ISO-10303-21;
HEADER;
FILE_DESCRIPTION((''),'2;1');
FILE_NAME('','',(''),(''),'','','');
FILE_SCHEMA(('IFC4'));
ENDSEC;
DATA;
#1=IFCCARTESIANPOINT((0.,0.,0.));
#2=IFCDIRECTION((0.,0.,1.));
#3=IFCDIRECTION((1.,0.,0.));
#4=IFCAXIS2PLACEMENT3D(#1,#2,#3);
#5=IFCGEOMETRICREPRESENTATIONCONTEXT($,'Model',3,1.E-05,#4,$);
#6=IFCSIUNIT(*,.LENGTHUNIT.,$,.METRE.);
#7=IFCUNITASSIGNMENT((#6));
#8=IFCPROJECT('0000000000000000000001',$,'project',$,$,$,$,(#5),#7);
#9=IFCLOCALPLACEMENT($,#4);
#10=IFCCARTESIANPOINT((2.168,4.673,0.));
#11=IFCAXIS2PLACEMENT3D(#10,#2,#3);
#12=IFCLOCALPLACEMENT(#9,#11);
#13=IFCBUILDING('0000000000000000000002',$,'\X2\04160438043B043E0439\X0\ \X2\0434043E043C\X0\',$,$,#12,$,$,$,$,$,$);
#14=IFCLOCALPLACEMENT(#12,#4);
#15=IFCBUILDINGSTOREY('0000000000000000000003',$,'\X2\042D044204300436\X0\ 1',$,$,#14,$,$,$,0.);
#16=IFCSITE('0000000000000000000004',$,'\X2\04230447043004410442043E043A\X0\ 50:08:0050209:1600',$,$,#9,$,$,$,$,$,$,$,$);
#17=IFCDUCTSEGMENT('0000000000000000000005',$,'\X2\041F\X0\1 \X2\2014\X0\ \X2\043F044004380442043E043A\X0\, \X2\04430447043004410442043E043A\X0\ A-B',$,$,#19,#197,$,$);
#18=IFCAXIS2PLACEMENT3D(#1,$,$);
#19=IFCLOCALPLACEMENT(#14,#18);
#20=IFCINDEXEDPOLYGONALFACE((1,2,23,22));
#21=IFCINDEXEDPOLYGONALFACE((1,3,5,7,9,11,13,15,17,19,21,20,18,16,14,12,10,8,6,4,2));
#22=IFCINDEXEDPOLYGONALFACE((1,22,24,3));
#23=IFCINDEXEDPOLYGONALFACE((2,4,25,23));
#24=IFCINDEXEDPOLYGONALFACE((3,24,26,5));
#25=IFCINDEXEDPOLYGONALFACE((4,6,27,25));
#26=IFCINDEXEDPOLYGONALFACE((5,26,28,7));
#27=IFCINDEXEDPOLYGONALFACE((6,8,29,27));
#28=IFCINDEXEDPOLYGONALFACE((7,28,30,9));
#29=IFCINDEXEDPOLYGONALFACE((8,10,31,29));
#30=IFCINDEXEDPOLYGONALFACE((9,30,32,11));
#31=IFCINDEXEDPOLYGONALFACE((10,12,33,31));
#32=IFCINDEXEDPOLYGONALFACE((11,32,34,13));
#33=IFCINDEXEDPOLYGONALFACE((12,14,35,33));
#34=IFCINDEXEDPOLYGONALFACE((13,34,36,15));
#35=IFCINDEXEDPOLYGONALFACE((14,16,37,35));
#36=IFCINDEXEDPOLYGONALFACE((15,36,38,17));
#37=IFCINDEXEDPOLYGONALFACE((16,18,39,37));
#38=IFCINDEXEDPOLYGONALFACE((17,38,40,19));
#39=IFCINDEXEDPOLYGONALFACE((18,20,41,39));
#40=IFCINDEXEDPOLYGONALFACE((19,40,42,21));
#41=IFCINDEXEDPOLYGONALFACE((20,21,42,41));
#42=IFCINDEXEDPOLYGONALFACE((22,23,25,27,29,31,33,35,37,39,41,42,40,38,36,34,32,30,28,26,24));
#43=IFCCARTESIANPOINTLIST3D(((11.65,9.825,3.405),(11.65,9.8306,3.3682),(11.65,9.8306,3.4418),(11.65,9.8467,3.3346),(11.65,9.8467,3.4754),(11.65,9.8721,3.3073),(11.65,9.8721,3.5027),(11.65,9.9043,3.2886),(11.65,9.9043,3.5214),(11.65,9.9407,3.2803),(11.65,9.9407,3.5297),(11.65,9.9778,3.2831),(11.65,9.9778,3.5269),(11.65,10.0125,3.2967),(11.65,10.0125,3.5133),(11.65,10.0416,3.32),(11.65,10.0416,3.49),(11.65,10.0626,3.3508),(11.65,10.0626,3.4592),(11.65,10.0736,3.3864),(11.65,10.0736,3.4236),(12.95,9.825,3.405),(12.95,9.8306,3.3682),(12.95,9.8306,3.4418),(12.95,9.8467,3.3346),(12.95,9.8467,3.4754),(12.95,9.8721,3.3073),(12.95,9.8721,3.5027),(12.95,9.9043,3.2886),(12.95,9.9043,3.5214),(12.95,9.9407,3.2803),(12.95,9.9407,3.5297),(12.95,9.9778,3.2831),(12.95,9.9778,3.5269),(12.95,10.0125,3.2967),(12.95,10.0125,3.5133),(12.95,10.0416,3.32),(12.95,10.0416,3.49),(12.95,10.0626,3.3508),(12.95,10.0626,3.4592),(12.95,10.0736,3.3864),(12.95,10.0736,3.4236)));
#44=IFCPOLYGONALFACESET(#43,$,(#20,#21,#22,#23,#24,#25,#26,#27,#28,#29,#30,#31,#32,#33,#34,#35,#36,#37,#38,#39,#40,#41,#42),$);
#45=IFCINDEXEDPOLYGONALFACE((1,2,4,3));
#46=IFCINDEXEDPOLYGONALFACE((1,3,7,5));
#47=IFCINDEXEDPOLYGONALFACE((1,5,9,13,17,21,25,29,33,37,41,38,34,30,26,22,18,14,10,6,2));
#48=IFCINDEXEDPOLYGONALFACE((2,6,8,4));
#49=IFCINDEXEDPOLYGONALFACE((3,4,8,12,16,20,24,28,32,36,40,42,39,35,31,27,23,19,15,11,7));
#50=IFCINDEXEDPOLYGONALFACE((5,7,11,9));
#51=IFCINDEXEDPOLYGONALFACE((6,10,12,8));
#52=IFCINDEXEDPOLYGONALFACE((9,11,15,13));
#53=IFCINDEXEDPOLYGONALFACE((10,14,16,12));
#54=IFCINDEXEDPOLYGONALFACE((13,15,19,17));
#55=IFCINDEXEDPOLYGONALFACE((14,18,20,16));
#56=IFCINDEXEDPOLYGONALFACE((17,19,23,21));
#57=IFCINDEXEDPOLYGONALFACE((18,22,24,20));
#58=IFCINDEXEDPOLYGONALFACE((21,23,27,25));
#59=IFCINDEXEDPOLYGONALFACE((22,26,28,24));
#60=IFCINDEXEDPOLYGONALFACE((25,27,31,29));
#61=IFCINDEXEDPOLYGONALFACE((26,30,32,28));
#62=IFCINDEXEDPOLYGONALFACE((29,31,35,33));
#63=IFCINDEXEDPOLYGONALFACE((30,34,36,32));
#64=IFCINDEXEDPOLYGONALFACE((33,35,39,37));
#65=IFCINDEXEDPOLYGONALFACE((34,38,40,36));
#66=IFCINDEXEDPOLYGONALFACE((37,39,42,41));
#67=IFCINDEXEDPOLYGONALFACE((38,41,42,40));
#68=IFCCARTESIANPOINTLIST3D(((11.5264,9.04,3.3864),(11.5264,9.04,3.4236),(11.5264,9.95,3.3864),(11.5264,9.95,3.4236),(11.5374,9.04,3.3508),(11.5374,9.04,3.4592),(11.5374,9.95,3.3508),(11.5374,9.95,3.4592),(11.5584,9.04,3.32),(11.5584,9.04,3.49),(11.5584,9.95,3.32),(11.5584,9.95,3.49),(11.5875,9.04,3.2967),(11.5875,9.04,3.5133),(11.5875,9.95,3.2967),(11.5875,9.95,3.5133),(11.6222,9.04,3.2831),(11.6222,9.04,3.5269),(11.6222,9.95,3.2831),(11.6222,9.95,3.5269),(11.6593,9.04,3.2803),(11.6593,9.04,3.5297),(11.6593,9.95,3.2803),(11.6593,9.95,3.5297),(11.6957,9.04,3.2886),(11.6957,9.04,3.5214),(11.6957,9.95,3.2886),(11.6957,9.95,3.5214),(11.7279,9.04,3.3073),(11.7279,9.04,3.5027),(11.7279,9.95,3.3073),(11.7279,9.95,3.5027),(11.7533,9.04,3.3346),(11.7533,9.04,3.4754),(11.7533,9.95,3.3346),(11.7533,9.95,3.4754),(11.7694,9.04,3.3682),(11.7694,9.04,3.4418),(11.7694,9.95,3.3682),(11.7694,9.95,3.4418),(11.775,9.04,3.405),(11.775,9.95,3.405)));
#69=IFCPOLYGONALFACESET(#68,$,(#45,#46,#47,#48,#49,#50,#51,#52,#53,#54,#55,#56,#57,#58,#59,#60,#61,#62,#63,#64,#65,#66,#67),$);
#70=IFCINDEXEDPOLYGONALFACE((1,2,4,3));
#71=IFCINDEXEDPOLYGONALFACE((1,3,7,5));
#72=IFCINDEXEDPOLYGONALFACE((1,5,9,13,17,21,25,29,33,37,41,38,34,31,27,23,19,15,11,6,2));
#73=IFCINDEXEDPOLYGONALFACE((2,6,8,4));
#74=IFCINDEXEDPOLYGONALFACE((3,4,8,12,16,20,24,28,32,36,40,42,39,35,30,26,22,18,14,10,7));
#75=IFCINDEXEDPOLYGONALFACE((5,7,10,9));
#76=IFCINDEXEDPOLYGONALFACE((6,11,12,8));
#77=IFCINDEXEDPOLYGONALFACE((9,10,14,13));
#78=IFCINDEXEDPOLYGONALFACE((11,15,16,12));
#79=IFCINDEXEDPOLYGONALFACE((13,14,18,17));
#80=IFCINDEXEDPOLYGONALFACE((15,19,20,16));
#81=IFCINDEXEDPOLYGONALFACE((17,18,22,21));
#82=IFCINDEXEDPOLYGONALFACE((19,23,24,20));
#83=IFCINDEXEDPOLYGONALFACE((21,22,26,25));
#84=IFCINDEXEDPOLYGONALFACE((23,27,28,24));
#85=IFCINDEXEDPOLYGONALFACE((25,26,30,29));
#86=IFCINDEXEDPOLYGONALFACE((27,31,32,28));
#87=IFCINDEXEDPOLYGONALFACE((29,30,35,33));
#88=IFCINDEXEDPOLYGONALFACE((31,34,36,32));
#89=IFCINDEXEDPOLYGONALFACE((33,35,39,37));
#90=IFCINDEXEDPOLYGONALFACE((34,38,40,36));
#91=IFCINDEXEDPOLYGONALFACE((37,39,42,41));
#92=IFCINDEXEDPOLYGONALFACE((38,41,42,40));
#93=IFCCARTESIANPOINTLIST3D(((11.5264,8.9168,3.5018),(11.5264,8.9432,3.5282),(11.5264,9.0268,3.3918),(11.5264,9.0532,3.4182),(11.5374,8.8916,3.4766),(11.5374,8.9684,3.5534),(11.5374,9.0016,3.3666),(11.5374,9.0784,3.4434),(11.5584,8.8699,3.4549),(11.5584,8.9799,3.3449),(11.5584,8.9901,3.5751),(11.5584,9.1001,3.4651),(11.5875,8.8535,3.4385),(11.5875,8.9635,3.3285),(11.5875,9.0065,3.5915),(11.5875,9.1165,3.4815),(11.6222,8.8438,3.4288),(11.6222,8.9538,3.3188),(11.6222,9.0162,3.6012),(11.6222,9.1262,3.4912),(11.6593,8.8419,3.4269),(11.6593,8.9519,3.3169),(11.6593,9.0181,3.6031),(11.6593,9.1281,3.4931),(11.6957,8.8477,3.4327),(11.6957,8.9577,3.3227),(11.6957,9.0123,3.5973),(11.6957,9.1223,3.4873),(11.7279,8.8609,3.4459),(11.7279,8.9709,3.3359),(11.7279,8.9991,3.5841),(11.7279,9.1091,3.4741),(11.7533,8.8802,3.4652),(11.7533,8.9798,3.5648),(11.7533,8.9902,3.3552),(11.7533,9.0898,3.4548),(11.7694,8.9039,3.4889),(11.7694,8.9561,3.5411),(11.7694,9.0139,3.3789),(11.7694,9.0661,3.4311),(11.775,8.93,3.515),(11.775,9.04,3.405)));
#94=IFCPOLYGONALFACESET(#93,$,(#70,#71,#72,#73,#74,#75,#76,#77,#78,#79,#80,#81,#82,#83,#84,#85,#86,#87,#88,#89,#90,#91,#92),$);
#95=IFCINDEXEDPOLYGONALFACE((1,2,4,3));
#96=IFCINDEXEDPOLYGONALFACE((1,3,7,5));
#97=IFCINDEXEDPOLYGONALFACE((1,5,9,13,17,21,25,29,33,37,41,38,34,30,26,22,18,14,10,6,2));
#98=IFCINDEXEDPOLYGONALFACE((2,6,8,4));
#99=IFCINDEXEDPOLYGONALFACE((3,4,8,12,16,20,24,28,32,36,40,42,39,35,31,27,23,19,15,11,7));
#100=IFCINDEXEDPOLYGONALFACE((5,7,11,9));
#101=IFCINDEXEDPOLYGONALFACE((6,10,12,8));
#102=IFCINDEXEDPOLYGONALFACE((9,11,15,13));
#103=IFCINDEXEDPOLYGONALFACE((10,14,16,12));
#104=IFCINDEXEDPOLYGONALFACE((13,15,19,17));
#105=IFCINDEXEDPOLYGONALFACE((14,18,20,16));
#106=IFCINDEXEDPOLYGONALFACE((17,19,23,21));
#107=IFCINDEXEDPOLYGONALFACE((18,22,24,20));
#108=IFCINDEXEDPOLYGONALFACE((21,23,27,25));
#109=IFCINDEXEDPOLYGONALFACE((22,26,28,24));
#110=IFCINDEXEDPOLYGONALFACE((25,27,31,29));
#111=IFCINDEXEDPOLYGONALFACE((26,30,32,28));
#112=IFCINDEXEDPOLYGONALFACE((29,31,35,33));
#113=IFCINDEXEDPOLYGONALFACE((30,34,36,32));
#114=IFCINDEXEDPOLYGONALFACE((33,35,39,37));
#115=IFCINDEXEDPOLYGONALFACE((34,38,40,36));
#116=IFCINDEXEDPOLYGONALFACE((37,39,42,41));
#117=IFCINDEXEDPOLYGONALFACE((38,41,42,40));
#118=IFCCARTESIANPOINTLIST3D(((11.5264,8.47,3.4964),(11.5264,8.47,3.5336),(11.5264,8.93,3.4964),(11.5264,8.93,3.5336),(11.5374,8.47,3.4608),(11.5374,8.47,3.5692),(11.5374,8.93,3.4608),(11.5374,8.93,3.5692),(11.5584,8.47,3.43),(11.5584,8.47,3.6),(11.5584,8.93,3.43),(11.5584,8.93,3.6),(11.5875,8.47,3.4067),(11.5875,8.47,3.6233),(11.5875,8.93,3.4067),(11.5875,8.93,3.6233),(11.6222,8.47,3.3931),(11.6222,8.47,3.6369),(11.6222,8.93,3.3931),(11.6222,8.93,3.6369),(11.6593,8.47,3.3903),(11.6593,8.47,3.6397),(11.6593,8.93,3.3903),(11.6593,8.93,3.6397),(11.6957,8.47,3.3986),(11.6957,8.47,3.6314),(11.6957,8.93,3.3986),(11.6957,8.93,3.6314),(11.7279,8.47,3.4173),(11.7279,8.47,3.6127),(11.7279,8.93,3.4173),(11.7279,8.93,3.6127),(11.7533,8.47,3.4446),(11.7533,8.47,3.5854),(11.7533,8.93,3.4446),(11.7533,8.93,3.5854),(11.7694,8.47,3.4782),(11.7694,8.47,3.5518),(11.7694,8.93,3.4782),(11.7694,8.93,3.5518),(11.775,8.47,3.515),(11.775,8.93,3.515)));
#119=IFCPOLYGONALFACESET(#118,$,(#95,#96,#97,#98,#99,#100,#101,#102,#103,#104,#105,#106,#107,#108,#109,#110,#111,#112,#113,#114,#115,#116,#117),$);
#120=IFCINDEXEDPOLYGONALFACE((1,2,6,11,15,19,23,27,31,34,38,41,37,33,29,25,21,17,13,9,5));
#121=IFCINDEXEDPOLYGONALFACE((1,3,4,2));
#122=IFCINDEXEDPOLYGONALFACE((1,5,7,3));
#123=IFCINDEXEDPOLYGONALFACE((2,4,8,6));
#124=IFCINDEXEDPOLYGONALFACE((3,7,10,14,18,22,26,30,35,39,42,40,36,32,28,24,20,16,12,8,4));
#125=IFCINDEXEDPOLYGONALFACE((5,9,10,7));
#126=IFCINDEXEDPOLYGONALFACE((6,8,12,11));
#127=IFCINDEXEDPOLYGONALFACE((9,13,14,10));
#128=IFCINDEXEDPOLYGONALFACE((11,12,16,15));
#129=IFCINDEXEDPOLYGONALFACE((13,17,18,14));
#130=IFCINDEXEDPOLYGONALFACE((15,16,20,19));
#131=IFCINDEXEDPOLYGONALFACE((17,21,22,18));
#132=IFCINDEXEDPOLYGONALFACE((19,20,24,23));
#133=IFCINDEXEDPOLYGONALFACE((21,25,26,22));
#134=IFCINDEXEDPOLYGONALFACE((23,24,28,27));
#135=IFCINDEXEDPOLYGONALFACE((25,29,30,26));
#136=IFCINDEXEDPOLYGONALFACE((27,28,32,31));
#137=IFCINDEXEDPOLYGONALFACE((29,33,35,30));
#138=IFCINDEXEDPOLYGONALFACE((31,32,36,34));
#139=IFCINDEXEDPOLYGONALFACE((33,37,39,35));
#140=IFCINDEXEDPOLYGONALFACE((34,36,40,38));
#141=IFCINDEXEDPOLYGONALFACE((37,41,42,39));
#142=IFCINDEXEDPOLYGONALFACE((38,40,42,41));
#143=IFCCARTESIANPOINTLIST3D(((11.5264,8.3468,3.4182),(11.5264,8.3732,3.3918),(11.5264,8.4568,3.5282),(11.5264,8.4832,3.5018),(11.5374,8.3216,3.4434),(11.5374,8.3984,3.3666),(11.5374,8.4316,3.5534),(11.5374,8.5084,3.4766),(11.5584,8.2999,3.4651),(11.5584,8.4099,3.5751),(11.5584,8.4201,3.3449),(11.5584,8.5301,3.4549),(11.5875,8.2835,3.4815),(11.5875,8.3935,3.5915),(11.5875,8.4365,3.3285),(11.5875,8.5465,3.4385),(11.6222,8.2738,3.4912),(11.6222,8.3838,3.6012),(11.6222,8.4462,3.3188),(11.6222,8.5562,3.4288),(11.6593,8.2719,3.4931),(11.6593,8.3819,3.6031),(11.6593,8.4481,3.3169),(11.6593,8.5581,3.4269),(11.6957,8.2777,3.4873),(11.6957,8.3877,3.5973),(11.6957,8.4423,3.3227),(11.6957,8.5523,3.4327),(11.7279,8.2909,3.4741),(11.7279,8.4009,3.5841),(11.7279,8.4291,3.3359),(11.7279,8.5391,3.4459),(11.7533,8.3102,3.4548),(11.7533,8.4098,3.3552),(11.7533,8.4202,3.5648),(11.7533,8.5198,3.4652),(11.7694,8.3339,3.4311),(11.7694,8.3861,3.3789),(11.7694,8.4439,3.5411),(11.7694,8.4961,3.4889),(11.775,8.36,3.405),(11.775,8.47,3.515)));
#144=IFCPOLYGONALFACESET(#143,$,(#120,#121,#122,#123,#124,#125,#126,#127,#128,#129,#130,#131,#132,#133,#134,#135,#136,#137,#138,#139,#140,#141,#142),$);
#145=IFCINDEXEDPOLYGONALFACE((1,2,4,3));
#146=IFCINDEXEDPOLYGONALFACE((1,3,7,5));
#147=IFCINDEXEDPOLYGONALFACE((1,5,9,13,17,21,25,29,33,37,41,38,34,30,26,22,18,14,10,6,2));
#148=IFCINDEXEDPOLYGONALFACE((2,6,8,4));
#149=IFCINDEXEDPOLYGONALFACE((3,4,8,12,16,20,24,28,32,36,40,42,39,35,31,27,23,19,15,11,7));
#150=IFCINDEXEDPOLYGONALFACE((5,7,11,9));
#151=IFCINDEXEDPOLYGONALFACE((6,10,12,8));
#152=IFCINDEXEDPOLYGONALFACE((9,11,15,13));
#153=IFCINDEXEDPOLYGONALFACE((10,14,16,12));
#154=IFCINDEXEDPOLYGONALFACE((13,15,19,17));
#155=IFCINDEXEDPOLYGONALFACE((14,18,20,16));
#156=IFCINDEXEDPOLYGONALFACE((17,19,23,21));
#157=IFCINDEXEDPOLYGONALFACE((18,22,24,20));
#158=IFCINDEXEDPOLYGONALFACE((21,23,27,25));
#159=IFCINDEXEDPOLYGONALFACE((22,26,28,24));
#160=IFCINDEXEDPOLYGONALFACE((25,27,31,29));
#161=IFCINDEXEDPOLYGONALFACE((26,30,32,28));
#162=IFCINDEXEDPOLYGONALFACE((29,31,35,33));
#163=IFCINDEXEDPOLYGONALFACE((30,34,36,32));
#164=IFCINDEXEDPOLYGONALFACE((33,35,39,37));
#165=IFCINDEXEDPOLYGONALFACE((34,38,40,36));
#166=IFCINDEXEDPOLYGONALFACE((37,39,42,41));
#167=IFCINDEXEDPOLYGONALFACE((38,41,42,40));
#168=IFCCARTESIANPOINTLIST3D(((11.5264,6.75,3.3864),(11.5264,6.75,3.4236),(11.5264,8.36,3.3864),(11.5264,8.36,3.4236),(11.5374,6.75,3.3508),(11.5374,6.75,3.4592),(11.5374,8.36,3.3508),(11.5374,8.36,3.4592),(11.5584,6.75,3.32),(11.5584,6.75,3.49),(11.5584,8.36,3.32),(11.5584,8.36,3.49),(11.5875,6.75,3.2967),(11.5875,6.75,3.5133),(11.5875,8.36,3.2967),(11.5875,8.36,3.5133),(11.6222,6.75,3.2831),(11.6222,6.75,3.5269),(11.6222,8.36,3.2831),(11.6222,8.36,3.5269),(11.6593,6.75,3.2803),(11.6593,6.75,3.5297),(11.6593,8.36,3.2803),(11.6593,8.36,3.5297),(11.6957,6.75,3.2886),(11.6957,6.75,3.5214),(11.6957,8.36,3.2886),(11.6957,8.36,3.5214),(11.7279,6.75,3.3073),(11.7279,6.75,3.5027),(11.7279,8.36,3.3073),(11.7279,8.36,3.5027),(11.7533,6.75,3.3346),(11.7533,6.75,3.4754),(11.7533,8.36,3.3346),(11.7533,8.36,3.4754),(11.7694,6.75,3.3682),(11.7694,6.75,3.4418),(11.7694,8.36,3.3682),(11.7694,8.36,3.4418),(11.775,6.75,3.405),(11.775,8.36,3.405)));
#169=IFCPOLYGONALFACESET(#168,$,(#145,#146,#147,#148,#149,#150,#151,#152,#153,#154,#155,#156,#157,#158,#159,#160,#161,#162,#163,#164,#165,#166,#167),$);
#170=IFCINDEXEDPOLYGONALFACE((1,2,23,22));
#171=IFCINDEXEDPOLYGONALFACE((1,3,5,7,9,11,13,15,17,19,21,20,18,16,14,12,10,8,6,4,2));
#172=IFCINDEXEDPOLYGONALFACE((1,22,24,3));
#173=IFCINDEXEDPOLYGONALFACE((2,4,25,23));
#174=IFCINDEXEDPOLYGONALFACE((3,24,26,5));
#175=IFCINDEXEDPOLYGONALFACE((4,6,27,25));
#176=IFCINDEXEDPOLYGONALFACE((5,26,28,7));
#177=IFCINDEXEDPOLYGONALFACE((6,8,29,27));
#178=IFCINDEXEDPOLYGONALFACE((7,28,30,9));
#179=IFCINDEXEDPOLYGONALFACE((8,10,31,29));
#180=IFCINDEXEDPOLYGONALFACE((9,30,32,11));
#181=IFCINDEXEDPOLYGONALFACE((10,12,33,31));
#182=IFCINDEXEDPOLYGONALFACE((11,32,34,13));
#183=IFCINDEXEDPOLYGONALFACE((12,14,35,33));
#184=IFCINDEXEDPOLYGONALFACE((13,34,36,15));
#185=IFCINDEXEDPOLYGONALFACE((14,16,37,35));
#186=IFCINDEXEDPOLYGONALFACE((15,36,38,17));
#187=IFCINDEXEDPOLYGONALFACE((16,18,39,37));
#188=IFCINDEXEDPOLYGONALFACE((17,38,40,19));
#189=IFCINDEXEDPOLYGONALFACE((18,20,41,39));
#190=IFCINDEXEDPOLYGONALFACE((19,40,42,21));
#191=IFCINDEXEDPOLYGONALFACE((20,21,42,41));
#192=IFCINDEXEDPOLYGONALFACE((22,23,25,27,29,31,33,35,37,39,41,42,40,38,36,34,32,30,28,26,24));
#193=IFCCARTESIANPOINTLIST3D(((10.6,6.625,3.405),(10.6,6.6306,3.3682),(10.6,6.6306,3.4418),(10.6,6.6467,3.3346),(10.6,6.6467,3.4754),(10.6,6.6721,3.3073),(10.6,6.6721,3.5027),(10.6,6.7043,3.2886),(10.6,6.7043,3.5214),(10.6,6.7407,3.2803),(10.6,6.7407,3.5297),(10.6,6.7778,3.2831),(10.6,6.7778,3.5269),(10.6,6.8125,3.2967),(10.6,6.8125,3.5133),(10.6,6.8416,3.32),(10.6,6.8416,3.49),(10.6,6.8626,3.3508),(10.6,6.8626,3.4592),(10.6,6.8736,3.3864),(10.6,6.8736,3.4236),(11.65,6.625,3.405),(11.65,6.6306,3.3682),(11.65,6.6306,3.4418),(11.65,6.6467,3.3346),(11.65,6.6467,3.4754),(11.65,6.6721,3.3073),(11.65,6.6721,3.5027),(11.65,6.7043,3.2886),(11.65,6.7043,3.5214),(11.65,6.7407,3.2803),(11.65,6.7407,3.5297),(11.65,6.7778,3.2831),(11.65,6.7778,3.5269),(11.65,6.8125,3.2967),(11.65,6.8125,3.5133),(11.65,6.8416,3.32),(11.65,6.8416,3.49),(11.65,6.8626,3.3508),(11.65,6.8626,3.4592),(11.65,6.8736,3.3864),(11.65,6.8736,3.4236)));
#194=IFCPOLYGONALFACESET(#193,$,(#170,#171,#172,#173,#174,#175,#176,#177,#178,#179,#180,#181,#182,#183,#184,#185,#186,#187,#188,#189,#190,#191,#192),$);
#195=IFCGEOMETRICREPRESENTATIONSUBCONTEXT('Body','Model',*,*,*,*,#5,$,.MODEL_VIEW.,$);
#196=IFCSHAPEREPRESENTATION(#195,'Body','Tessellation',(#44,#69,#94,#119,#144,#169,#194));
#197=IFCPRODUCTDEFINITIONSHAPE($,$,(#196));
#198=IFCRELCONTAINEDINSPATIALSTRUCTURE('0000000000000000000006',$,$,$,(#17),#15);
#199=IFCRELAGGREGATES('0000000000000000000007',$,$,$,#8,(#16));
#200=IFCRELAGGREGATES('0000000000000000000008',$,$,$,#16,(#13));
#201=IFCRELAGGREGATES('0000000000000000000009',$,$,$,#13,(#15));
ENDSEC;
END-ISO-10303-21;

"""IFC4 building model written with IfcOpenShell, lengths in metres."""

from ifc_helpers import new_model, si_unit, frame, origin_with_axes, origin_2d, place, context, subcontext, project, spatial, circle, extrude, element, save


model = new_model("IFC4")

# Units and contexts
model_context = context("Model", 3, precision=1e-05, world=origin_with_axes())
body_context = subcontext(model_context, "Body", "Model", "MODEL_VIEW")
ifc_project = project(units=[si_unit("LENGTHUNIT", "METRE")], contexts=[model_context])

# Site, building, storey
site_placement = place(None, origin_with_axes())
site = spatial("IfcSite", under=ifc_project, at=site_placement, Name="Участок 50:08:0050209:1600")
building_placement = place(site_placement, frame((2.168, 4.673, 0.0), z_axis=(0.0, 0.0, 1.0), x_axis=(1.0, 0.0, 0.0)))
building = spatial("IfcBuilding", under=site, at=building_placement, Name="Жилой дом")
storey_placement = place(building_placement, origin_with_axes())
storey = spatial("IfcBuildingStorey", under=building, at=storey_placement, Name="Этаж 1", Elevation=0.0)

# Duct segment
duct_segment_1_placement = place(storey_placement, origin_with_axes())
element("IfcDuctSegment", 1, at=duct_segment_1_placement, inside=storey, Name="П1 — приток, участок A-B", context=body_context, shape_type="SweptSolid", body=[
    extrude(circle(Radius=0.125, at=origin_2d()), frame((12.95, 9.95, 3.405), z_axis=(-1.0, 0.0, 0.0), x_axis=(0.0, -1.0, 0.0)), (0.0, 0.0, 1.0), 1.3),
    extrude(circle(Radius=0.125, at=origin_2d()), frame((11.65, 9.95, 3.405), z_axis=(0.0, -1.0, 0.0), x_axis=(1.0, 0.0, 0.0)), (0.0, 0.0, 1.0), 0.91),
    extrude(circle(Radius=0.125, at=origin_2d()), frame((11.65, 9.04, 3.405), z_axis=(0.0, -0.707107, 0.707107), x_axis=(1.0, 0.0, 0.0)), (0.0, 0.0, 1.0), 0.1556),
    extrude(circle(Radius=0.125, at=origin_2d()), frame((11.65, 8.93, 3.515), z_axis=(0.0, -1.0, 0.0), x_axis=(1.0, 0.0, 0.0)), (0.0, 0.0, 1.0), 0.46),
    extrude(circle(Radius=0.125, at=origin_2d()), frame((11.65, 8.47, 3.515), z_axis=(0.0, -0.707107, -0.707107), x_axis=(1.0, 0.0, 0.0)), (0.0, 0.0, 1.0), 0.1556),
    extrude(circle(Radius=0.125, at=origin_2d()), frame((11.65, 8.36, 3.405), z_axis=(0.0, -1.0, 0.0), x_axis=(1.0, 0.0, 0.0)), (0.0, 0.0, 1.0), 1.61),
    extrude(circle(Radius=0.125, at=origin_2d()), frame((11.65, 6.75, 3.405), z_axis=(-1.0, 0.0, 0.0), x_axis=(0.0, -1.0, 0.0)), (0.0, 0.0, 1.0), 1.05),
])

save(model, "model.ifc")
